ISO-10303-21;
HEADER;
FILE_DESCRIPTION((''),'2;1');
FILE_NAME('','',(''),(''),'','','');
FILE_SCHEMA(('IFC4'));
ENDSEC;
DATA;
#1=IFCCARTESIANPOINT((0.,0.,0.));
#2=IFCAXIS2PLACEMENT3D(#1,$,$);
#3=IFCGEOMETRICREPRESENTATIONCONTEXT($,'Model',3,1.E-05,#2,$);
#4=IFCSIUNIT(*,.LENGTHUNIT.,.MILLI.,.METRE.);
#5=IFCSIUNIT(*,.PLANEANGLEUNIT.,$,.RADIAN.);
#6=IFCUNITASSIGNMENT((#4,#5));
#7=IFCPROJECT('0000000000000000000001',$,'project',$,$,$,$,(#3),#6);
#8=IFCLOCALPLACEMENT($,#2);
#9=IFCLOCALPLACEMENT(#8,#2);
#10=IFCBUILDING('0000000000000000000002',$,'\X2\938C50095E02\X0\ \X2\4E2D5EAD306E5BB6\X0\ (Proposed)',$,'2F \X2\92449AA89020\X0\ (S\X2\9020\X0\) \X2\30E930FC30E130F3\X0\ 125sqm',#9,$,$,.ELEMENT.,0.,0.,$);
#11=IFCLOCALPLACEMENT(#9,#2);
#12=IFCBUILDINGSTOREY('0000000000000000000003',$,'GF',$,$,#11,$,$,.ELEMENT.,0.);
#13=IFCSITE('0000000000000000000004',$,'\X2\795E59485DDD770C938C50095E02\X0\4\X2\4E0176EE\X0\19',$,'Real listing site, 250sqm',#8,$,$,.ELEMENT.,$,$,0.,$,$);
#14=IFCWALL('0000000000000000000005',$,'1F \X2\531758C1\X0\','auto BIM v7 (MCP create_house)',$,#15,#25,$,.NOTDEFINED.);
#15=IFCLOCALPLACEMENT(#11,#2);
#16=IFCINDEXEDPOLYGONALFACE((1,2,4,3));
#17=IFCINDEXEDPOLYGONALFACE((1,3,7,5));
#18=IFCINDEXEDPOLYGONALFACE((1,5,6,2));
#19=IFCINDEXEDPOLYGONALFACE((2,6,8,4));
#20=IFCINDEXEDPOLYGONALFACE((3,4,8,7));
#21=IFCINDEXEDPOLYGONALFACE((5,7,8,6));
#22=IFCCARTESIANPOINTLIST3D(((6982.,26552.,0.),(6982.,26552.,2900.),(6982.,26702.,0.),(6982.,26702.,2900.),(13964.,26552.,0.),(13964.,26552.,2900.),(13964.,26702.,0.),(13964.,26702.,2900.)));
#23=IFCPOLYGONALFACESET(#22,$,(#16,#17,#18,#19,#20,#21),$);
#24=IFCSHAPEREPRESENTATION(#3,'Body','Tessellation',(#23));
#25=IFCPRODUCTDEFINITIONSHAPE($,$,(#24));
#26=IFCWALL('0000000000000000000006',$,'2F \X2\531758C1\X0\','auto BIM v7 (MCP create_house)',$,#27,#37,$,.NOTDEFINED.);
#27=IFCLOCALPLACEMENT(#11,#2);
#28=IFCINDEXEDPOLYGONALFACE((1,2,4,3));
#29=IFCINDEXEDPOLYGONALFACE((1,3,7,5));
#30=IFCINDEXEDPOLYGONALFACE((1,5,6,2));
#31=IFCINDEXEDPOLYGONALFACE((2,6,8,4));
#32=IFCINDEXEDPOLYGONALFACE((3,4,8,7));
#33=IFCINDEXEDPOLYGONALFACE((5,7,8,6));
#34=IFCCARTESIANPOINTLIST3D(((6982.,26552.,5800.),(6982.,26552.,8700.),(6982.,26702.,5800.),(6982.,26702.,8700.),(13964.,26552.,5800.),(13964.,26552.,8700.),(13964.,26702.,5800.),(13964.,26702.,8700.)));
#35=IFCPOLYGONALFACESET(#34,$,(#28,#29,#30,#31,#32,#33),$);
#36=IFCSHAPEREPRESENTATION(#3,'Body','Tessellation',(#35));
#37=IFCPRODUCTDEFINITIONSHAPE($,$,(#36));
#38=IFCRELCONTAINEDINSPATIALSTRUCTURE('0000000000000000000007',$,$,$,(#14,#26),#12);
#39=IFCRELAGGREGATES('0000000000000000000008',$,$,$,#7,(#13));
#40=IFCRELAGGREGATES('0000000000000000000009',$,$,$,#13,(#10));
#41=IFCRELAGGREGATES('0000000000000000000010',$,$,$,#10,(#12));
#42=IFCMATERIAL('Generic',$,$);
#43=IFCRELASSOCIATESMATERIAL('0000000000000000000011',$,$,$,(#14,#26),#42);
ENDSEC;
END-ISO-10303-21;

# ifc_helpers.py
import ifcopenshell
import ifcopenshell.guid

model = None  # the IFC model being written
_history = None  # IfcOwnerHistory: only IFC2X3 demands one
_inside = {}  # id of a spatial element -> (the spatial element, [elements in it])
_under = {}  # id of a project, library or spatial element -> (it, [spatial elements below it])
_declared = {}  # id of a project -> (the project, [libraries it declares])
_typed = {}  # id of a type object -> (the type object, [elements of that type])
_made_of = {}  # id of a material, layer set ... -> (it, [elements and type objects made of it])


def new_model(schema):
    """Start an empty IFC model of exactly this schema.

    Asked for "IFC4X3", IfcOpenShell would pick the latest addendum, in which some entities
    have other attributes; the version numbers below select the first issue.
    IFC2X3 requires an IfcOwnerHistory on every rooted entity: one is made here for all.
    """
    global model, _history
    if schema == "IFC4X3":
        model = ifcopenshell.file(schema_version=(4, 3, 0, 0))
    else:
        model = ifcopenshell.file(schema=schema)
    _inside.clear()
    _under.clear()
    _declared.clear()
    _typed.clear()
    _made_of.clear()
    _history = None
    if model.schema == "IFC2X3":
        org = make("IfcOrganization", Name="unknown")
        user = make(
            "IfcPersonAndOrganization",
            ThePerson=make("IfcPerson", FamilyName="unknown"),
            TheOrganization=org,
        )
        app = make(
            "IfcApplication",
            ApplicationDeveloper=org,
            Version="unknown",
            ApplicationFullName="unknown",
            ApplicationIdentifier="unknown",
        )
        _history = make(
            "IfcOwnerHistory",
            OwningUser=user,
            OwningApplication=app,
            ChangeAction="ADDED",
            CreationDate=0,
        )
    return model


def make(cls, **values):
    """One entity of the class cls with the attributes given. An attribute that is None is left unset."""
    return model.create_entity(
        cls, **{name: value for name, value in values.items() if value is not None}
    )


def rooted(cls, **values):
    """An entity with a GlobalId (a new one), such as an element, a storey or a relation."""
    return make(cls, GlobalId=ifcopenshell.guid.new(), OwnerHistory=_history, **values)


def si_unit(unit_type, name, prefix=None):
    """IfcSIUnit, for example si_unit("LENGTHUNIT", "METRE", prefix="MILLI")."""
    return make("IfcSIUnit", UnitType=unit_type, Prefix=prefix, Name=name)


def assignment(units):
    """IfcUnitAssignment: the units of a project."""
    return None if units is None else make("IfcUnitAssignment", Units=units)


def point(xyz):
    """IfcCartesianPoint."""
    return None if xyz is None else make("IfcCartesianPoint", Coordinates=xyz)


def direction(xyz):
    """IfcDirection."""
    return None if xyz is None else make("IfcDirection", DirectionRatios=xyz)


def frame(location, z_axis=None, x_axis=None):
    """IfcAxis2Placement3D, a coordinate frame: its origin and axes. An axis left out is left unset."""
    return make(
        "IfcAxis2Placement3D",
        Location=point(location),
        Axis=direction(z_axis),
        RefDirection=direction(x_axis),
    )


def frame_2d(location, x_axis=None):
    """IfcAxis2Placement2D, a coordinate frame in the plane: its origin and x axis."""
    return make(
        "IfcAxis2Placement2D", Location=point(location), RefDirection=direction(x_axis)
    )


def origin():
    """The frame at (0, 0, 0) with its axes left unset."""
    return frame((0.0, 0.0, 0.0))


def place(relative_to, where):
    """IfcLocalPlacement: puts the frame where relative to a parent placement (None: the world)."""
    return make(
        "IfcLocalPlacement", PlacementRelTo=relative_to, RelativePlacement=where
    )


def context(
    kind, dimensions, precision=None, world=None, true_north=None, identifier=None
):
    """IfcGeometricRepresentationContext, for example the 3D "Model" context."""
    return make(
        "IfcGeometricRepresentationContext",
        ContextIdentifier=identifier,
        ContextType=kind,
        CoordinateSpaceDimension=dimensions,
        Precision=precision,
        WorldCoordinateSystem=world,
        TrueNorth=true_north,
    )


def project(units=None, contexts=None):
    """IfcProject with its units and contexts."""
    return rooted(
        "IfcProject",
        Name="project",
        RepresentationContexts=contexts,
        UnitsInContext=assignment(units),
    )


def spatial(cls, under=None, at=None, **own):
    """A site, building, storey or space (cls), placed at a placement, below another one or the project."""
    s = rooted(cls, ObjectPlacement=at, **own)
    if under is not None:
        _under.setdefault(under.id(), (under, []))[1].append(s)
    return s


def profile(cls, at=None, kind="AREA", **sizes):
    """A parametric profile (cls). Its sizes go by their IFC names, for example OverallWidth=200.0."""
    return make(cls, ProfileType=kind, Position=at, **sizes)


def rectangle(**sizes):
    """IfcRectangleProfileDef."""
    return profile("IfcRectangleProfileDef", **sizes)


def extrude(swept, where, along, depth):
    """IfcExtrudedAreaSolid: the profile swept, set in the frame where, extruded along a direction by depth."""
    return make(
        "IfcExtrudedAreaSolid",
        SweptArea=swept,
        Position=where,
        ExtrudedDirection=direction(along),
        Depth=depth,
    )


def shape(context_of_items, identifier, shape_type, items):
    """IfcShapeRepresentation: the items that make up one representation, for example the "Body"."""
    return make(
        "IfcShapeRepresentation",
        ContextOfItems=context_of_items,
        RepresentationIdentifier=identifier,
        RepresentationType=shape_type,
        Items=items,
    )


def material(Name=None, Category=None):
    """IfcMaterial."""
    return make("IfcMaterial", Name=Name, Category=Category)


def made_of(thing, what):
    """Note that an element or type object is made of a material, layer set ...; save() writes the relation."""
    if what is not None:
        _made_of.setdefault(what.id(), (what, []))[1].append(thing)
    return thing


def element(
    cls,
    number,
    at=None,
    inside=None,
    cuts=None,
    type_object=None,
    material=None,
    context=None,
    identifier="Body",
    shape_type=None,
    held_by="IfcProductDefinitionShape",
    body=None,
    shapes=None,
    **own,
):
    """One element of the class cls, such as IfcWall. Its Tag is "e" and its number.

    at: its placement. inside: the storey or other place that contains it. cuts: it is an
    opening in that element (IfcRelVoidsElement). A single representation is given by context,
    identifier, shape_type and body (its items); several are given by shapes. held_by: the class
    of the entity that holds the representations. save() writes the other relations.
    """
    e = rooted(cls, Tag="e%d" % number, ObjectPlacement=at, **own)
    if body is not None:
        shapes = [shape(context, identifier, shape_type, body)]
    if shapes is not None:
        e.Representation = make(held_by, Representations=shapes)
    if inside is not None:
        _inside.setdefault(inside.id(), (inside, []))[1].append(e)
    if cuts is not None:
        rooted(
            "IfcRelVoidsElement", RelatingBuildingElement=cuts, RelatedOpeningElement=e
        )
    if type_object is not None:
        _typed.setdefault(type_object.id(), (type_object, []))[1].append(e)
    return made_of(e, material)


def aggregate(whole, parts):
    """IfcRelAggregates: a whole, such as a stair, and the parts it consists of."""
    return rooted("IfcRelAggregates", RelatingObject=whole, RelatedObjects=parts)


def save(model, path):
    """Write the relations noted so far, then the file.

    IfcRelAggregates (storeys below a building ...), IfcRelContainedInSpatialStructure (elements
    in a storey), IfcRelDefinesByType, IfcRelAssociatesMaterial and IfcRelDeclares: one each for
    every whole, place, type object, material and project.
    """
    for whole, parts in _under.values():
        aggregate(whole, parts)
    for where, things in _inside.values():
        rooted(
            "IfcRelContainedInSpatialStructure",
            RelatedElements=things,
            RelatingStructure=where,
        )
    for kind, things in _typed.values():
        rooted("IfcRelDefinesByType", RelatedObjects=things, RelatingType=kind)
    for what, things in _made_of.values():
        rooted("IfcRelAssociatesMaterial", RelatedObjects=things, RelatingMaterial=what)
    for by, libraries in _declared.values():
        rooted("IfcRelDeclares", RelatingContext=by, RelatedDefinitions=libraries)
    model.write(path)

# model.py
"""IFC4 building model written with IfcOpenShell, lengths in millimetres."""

from ifc_helpers import new_model, si_unit, frame, frame_2d, origin, place, context, project, spatial, rectangle, extrude, material, element, save


model = new_model("IFC4")

# Units and contexts
model_context = context("Model", 3, precision=1e-05, world=origin())
ifc_project = project(units=[si_unit("LENGTHUNIT", "METRE", prefix="MILLI"), si_unit("PLANEANGLEUNIT", "RADIAN")], contexts=[model_context])

# Site, building, storey
site_placement = place(None, origin())
site = spatial("IfcSite", under=ifc_project, at=site_placement, Name="神奈川県鎌倉市4丁目19", ObjectType="Real listing site, 250sqm", CompositionType="ELEMENT", RefElevation=0.0)
building_placement = place(site_placement, origin())
building = spatial("IfcBuilding", under=site, at=building_placement, Name="鎌倉市 中庭の家 (Proposed)", ObjectType="2F 鉄骨造 (S造) ラーメン 125sqm", CompositionType="ELEMENT", ElevationOfRefHeight=0.0, ElevationOfTerrain=0.0)
storey_placement = place(building_placement, origin())
storey = spatial("IfcBuildingStorey", under=building, at=storey_placement, Name="GF", CompositionType="ELEMENT", Elevation=0.0)

# Shared definitions
ifc_material = material(Name="Generic")

# Wall
wall_1_placement = place(storey_placement, frame((3491.0, 13276.0, 0.0)))
element("IfcWall", 1, at=wall_1_placement, inside=storey, material=ifc_material, Name="1F 北壁", Description="auto BIM v7 (MCP create_house)", PredefinedType="NOTDEFINED", context=model_context, shape_type="SweptSolid", body=[
    extrude(rectangle(XDim=6982.0, YDim=150.0, at=frame_2d((3491.0, 75.0))), frame((3491.0, 13276.0, 0.0)), (0.0, 0.0, 1.0), 2900.0),
])

# Wall
wall_2_placement = place(storey_placement, frame((3491.0, 13276.0, 2900.0)))
element("IfcWall", 2, at=wall_2_placement, inside=storey, material=ifc_material, Name="2F 北壁", Description="auto BIM v7 (MCP create_house)", PredefinedType="NOTDEFINED", context=model_context, shape_type="SweptSolid", body=[
    extrude(rectangle(XDim=6982.0, YDim=150.0, at=frame_2d((3491.0, 75.0))), frame((3491.0, 13276.0, 2900.0)), (0.0, 0.0, 1.0), 2900.0),
])

save(model, "model.ifc")
